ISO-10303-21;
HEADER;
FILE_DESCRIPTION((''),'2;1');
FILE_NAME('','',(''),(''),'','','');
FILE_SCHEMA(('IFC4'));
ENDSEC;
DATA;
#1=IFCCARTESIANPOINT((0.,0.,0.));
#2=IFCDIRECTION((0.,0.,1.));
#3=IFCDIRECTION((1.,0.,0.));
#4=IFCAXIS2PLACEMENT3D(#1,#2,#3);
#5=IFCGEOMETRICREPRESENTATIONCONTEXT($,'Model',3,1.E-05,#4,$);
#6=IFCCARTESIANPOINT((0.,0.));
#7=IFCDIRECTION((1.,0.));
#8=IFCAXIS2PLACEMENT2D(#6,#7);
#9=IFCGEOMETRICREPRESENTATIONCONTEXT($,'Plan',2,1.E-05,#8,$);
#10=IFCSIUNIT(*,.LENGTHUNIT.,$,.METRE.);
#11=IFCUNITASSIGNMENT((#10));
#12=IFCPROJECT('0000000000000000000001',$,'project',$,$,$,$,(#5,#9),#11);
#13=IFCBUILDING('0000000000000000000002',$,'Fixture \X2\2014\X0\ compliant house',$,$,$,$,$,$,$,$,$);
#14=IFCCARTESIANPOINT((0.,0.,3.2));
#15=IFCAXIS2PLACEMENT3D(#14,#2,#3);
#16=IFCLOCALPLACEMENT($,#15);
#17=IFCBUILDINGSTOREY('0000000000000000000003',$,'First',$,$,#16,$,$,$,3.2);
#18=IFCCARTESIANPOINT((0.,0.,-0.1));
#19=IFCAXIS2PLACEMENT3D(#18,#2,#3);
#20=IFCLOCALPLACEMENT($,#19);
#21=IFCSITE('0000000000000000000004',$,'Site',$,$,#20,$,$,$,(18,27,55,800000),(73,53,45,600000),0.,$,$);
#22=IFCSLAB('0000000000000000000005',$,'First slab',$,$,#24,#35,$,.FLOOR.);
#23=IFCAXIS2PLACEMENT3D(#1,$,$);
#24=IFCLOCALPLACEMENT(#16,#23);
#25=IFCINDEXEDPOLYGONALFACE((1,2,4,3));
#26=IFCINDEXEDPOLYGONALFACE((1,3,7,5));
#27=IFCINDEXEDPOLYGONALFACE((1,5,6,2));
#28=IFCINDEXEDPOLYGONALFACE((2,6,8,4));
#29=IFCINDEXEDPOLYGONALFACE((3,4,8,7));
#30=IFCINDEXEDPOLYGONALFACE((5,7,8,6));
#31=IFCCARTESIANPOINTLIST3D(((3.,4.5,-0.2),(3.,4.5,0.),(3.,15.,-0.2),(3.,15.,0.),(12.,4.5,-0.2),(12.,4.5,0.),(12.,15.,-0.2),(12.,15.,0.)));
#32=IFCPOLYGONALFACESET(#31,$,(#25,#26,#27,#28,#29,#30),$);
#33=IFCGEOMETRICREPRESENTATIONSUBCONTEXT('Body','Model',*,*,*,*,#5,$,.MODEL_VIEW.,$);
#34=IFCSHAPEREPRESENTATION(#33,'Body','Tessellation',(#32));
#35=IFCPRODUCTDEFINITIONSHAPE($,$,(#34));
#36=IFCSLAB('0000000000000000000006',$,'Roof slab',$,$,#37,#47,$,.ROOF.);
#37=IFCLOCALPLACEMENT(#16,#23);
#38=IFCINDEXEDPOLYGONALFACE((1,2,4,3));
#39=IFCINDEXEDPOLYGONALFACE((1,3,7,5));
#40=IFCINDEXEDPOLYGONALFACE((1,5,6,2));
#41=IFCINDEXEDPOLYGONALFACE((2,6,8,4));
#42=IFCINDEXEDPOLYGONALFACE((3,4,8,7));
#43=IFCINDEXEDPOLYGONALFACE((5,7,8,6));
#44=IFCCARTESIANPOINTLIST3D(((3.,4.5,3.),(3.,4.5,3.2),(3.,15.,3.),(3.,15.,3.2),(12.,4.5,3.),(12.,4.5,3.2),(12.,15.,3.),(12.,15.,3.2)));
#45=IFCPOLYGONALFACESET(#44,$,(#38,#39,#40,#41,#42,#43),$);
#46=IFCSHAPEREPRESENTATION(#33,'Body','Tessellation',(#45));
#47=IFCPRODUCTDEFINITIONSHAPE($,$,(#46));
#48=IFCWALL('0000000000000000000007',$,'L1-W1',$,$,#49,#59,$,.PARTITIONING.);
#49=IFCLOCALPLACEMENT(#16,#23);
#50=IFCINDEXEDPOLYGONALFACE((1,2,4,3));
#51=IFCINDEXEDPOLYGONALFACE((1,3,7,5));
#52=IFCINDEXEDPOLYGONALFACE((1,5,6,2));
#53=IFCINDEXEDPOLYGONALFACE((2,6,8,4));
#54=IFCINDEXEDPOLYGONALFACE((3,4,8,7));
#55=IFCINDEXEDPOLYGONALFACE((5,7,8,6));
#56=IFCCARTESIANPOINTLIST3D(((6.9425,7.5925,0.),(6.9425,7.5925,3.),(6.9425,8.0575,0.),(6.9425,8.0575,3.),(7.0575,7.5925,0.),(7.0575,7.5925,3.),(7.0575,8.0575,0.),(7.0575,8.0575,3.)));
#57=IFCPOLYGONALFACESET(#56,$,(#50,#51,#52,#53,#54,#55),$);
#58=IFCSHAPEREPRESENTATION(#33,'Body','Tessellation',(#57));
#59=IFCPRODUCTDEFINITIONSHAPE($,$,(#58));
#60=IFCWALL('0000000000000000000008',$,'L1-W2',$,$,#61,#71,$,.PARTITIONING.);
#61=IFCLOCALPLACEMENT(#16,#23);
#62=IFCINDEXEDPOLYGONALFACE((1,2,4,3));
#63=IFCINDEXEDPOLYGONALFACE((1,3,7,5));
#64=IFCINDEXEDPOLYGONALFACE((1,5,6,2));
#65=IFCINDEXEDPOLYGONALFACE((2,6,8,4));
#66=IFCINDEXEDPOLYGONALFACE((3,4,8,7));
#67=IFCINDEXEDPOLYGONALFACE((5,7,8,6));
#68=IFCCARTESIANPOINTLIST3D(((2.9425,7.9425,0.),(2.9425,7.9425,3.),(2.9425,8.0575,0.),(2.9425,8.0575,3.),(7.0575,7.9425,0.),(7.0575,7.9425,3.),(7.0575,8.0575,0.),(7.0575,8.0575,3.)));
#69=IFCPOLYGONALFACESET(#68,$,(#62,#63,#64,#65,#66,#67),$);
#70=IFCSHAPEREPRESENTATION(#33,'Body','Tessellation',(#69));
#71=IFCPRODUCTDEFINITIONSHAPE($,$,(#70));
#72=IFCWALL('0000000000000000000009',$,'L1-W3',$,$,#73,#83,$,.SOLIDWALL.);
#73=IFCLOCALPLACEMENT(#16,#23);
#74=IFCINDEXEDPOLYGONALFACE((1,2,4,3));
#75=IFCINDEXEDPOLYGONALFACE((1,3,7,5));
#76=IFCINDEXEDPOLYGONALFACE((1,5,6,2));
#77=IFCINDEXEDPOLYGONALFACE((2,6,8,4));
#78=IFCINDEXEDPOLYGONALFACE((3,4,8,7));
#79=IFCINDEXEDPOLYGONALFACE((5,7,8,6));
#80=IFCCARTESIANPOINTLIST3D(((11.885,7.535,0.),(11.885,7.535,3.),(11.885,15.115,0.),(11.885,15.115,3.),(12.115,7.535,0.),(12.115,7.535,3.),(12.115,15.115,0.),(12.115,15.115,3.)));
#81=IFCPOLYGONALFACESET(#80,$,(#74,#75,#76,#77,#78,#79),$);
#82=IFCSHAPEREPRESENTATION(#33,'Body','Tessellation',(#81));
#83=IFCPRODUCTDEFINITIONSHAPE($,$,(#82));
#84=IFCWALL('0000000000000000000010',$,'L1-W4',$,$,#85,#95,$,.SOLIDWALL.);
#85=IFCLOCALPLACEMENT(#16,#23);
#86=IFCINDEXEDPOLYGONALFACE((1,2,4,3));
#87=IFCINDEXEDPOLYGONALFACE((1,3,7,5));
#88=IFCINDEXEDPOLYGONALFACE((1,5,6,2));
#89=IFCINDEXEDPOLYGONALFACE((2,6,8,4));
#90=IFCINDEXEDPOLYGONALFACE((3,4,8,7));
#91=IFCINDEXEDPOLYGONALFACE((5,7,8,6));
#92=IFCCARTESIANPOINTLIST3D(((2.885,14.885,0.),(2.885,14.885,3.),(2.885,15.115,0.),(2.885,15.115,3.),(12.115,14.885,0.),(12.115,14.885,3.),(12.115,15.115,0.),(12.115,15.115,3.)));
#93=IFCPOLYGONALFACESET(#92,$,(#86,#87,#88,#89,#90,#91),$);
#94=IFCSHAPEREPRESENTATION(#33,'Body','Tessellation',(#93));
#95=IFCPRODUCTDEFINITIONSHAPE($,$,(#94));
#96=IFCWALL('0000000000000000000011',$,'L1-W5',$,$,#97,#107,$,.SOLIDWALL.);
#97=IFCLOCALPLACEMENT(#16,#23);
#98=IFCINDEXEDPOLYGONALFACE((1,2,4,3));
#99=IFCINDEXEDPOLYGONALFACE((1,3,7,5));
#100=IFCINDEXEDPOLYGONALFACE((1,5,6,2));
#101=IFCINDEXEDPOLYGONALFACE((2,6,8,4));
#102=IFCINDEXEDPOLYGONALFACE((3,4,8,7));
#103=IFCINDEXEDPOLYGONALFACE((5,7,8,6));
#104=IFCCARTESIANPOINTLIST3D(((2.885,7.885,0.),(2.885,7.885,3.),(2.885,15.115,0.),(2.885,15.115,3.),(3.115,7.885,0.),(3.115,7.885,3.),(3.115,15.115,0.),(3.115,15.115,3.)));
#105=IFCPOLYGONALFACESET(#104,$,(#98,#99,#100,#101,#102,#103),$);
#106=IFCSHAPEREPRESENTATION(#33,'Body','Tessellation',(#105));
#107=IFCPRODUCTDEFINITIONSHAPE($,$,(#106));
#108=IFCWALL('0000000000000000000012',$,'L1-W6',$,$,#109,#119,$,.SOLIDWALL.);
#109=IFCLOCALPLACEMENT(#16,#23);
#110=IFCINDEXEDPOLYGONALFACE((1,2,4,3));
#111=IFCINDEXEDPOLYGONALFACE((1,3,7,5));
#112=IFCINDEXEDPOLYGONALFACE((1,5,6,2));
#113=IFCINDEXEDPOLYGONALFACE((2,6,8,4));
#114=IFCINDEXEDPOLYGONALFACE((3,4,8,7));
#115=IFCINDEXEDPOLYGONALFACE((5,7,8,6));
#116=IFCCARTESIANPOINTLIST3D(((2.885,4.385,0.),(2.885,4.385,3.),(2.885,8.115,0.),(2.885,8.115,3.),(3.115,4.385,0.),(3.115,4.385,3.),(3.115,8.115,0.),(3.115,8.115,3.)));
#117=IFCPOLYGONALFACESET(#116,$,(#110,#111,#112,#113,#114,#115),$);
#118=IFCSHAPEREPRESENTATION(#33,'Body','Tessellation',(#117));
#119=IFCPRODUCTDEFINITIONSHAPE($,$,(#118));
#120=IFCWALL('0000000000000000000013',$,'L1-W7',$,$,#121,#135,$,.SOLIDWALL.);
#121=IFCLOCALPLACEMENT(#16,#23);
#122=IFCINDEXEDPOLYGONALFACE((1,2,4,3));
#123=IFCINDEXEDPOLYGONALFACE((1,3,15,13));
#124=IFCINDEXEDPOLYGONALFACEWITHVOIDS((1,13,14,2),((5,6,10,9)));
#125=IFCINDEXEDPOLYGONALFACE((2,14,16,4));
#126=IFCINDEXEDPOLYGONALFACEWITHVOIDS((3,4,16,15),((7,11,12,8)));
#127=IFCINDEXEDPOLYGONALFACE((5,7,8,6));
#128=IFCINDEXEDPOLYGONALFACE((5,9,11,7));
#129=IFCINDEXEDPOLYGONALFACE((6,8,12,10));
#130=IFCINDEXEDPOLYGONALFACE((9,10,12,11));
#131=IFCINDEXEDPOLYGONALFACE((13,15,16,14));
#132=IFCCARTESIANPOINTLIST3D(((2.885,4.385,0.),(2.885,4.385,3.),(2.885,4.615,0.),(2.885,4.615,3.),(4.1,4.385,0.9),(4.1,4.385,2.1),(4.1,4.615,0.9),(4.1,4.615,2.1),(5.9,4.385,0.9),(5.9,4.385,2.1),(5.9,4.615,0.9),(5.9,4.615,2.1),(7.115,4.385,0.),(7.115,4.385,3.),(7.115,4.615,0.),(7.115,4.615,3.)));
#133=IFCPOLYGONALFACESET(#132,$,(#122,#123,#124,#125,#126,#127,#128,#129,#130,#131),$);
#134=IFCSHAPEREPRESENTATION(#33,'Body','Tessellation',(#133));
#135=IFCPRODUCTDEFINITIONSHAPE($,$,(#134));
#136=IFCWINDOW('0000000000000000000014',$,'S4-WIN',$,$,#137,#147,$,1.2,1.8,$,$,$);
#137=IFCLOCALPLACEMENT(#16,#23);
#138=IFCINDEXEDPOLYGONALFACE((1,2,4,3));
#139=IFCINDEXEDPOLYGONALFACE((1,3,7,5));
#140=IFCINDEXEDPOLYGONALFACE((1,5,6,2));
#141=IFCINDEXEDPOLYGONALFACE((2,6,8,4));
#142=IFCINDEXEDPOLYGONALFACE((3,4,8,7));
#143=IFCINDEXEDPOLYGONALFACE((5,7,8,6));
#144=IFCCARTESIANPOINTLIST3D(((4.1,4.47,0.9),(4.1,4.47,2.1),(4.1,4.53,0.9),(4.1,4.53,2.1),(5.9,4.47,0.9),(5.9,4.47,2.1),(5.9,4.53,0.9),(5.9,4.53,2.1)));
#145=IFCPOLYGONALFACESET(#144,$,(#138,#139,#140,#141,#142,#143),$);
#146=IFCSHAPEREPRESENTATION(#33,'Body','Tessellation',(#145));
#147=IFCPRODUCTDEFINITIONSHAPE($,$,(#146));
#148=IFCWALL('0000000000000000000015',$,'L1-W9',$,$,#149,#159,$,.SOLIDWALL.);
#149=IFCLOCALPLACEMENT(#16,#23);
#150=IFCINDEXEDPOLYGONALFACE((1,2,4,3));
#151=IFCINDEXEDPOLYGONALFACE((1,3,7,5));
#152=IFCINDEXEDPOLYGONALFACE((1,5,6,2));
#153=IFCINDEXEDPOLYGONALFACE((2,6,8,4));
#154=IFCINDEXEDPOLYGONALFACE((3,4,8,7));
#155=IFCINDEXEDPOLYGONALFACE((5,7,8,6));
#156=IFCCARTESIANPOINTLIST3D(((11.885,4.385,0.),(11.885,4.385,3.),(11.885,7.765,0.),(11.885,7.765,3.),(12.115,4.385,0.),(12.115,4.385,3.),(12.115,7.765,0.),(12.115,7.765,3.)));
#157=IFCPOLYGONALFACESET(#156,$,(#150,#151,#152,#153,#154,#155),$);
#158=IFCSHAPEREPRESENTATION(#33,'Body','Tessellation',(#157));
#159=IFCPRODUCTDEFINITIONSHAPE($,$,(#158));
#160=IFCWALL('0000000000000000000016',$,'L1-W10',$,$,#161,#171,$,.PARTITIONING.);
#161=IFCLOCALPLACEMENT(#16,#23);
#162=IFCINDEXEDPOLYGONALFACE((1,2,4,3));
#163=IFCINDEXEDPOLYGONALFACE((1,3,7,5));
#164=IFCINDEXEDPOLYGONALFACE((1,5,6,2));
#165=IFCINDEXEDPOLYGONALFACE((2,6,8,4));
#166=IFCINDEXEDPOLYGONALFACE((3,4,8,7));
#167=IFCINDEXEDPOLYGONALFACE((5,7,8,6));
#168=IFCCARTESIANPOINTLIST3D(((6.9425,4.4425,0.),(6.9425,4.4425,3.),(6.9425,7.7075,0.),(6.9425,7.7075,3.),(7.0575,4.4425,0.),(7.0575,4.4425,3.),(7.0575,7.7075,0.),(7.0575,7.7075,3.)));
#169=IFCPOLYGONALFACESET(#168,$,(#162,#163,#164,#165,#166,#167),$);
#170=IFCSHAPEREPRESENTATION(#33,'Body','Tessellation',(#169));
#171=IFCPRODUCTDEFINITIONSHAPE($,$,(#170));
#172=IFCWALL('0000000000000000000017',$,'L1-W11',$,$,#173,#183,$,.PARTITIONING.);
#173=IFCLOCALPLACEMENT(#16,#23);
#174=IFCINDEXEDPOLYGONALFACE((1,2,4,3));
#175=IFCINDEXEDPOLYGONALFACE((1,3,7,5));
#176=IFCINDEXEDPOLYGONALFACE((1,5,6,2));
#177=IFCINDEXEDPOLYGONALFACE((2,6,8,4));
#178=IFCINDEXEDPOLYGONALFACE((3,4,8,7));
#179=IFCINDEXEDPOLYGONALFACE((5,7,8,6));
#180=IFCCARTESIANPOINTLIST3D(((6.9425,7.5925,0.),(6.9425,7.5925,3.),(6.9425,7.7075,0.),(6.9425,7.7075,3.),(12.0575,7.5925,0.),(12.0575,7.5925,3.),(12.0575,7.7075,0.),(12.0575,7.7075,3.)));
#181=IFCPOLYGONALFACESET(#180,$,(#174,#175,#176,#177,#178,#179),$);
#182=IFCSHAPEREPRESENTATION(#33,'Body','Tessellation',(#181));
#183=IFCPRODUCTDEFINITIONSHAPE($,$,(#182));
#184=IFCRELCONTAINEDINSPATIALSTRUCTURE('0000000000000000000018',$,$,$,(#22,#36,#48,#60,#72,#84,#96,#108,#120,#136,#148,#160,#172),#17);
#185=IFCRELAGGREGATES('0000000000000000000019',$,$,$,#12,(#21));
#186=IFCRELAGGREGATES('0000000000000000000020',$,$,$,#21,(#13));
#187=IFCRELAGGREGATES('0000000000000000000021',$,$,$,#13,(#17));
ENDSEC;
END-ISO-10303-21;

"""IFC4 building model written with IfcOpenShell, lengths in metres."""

from ifc_helpers import new_model, si_unit, frame, origin_with_axes, origin_2d_with_axis, place, context, subcontext, project, spatial, line, indexed_curve, outline, extrude, element, fill, save


model = new_model("IFC4")

# Units and contexts
model_context = context("Model", 3, precision=1e-05, world=origin_with_axes())
plan_context = context("Plan", 2, precision=1e-05, world=origin_2d_with_axis())
body_context = subcontext(model_context, "Body", "Model", "MODEL_VIEW")
ifc_project = project(units=[si_unit("LENGTHUNIT", "METRE")], contexts=[model_context, plan_context])

# Site, building, storey
site_placement = place(None, frame((0.0, 0.0, -0.1), z_axis=(0.0, 0.0, 1.0), x_axis=(1.0, 0.0, 0.0)))
site = spatial("IfcSite", under=ifc_project, at=site_placement, Name="Site", RefLatitude=(18, 27, 55, 800000), RefLongitude=(73, 53, 45, 600000), RefElevation=0.0)
building = spatial("IfcBuilding", under=site, Name="Fixture — compliant house")
storey_placement = place(None, frame((0.0, 0.0, 3.2), z_axis=(0.0, 0.0, 1.0), x_axis=(1.0, 0.0, 0.0)))
storey = spatial("IfcBuildingStorey", under=building, at=storey_placement, Name="First", Elevation=3.2)

# Slabs
slab_1_placement = place(storey_placement, frame((0.0, 0.0, -0.2), z_axis=(0.0, 0.0, 1.0), x_axis=(1.0, 0.0, 0.0)))
element("IfcSlab", 1, at=slab_1_placement, inside=storey, Name="First slab", PredefinedType="FLOOR", context=body_context, shape_type="SweptSolid", body=[
    extrude(outline(indexed_curve([(3.0, 4.5), (12.0, 4.5), (12.0, 15.0), (3.0, 15.0)], segments=[line(1, 2, 3, 4, 1)])), origin_with_axes(), (0.0, 0.0, 1.0), 0.2),
])
slab_2_placement = place(storey_placement, frame((0.0, 0.0, 3.0), z_axis=(0.0, 0.0, 1.0), x_axis=(1.0, 0.0, 0.0)))
element("IfcSlab", 2, at=slab_2_placement, inside=storey, Name="Roof slab", PredefinedType="ROOF", context=body_context, shape_type="SweptSolid", body=[
    extrude(outline(indexed_curve([(3.0, 4.5), (12.0, 4.5), (12.0, 15.0), (3.0, 15.0)], segments=[line(1, 2, 3, 4, 1)])), origin_with_axes(), (0.0, 0.0, 1.0), 0.2),
])

# Walls
wall_1_placement = place(storey_placement, frame((0.0, 0.0, -3.2), z_axis=(0.0, 0.0, 1.0), x_axis=(1.0, 0.0, 0.0)))
element("IfcWall", 3, at=wall_1_placement, inside=storey, Name="L1-W1", PredefinedType="PARTITIONING", context=body_context, shape_type="SweptSolid", body=[
    extrude(outline(indexed_curve([(6.9425, 7.5925), (6.9425, 8.0575), (7.0575, 8.0575), (7.0575, 7.5925)], segments=[line(1, 2, 3, 4, 1)])), frame((0.0, 0.0, 3.2), z_axis=(0.0, 0.0, 1.0), x_axis=(1.0, 0.0, 0.0)), (0.0, 0.0, 1.0), 3.0),
])
wall_2_placement = place(storey_placement, frame((0.0, 0.0, -3.2), z_axis=(0.0, 0.0, 1.0), x_axis=(1.0, 0.0, 0.0)))
element("IfcWall", 4, at=wall_2_placement, inside=storey, Name="L1-W2", PredefinedType="PARTITIONING", context=body_context, shape_type="SweptSolid", body=[
    extrude(outline(indexed_curve([(7.0575, 7.9425), (2.9425, 7.9425), (2.9425, 8.0575), (7.0575, 8.0575)], segments=[line(1, 2, 3, 4, 1)])), frame((0.0, 0.0, 3.2), z_axis=(0.0, 0.0, 1.0), x_axis=(1.0, 0.0, 0.0)), (0.0, 0.0, 1.0), 3.0),
])
wall_3_placement = place(storey_placement, frame((0.0, 0.0, -3.2), z_axis=(0.0, 0.0, 1.0), x_axis=(1.0, 0.0, 0.0)))
element("IfcWall", 5, at=wall_3_placement, inside=storey, Name="L1-W3", PredefinedType="SOLIDWALL", context=body_context, shape_type="SweptSolid", body=[
    extrude(outline(indexed_curve([(11.885, 7.535), (11.885, 15.115), (12.115, 15.115), (12.115, 7.535)], segments=[line(1, 2, 3, 4, 1)])), frame((0.0, 0.0, 3.2), z_axis=(0.0, 0.0, 1.0), x_axis=(1.0, 0.0, 0.0)), (0.0, 0.0, 1.0), 3.0),
])
wall_4_placement = place(storey_placement, frame((0.0, 0.0, -3.2), z_axis=(0.0, 0.0, 1.0), x_axis=(1.0, 0.0, 0.0)))
element("IfcWall", 6, at=wall_4_placement, inside=storey, Name="L1-W4", PredefinedType="SOLIDWALL", context=body_context, shape_type="SweptSolid", body=[
    extrude(outline(indexed_curve([(12.115, 14.885), (2.885, 14.885), (2.885, 15.115), (12.115, 15.115)], segments=[line(1, 2, 3, 4, 1)])), frame((0.0, 0.0, 3.2), z_axis=(0.0, 0.0, 1.0), x_axis=(1.0, 0.0, 0.0)), (0.0, 0.0, 1.0), 3.0),
])
wall_5_placement = place(storey_placement, frame((0.0, 0.0, -3.2), z_axis=(0.0, 0.0, 1.0), x_axis=(1.0, 0.0, 0.0)))
element("IfcWall", 7, at=wall_5_placement, inside=storey, Name="L1-W5", PredefinedType="SOLIDWALL", context=body_context, shape_type="SweptSolid", body=[
    extrude(outline(indexed_curve([(3.115, 15.115), (3.115, 7.885), (2.885, 7.885), (2.885, 15.115)], segments=[line(1, 2, 3, 4, 1)])), frame((0.0, 0.0, 3.2), z_axis=(0.0, 0.0, 1.0), x_axis=(1.0, 0.0, 0.0)), (0.0, 0.0, 1.0), 3.0),
])
wall_6_placement = place(storey_placement, frame((0.0, 0.0, -3.2), z_axis=(0.0, 0.0, 1.0), x_axis=(1.0, 0.0, 0.0)))
element("IfcWall", 8, at=wall_6_placement, inside=storey, Name="L1-W6", PredefinedType="SOLIDWALL", context=body_context, shape_type="SweptSolid", body=[
    extrude(outline(indexed_curve([(3.115, 8.115), (3.115, 4.385), (2.885, 4.385), (2.885, 8.115)], segments=[line(1, 2, 3, 4, 1)])), frame((0.0, 0.0, 3.2), z_axis=(0.0, 0.0, 1.0), x_axis=(1.0, 0.0, 0.0)), (0.0, 0.0, 1.0), 3.0),
])

# Wall, opening, window
wall_7_placement = place(storey_placement, frame((0.0, 0.0, -3.2), z_axis=(0.0, 0.0, 1.0), x_axis=(1.0, 0.0, 0.0)))
wall_7 = element("IfcWall", 9, at=wall_7_placement, inside=storey, Name="L1-W7", PredefinedType="SOLIDWALL", context=body_context, shape_type="SweptSolid", body=[
    extrude(outline(indexed_curve([(2.885, 4.615), (7.115, 4.615), (7.115, 4.385), (2.885, 4.385)], segments=[line(1, 2, 3, 4, 1)])), frame((0.0, 0.0, 3.2), z_axis=(0.0, 0.0, 1.0), x_axis=(1.0, 0.0, 0.0)), (0.0, 0.0, 1.0), 3.0),
])
opening_1_placement = place(wall_7_placement, origin_with_axes())
opening_1 = element("IfcOpeningElement", 10, at=opening_1_placement, cuts=wall_7, context=body_context, shape_type="SweptSolid", body=[
    extrude(outline(indexed_curve([(4.1, 4.665), (5.9, 4.665), (5.9, 4.335), (4.1, 4.335)], segments=[line(1, 2, 3, 4, 1)])), frame((0.0, 0.0, 4.1), z_axis=(0.0, 0.0, 1.0), x_axis=(1.0, 0.0, 0.0)), (0.0, 0.0, 1.0), 1.2),
])
window_1_placement = place(storey_placement, frame((0.0, 0.0, -3.2), z_axis=(0.0, 0.0, 1.0), x_axis=(1.0, 0.0, 0.0)))
window_1 = element("IfcWindow", 11, at=window_1_placement, inside=storey, Name="S4-WIN", OverallHeight=1.2, OverallWidth=1.8, context=body_context, shape_type="SweptSolid", body=[
    extrude(outline(indexed_curve([(4.1, 4.53), (5.9, 4.53), (5.9, 4.47), (4.1, 4.47)], segments=[line(1, 2, 3, 4, 1)])), frame((0.0, 0.0, 4.1), z_axis=(0.0, 0.0, 1.0), x_axis=(1.0, 0.0, 0.0)), (0.0, 0.0, 1.0), 1.2),
])
fill(opening_1, window_1)

# Walls
wall_8_placement = place(storey_placement, frame((0.0, 0.0, -3.2), z_axis=(0.0, 0.0, 1.0), x_axis=(1.0, 0.0, 0.0)))
element("IfcWall", 12, at=wall_8_placement, inside=storey, Name="L1-W9", PredefinedType="SOLIDWALL", context=body_context, shape_type="SweptSolid", body=[
    extrude(outline(indexed_curve([(11.885, 4.385), (11.885, 7.765), (12.115, 7.765), (12.115, 4.385)], segments=[line(1, 2, 3, 4, 1)])), frame((0.0, 0.0, 3.2), z_axis=(0.0, 0.0, 1.0), x_axis=(1.0, 0.0, 0.0)), (0.0, 0.0, 1.0), 3.0),
])
wall_9_placement = place(storey_placement, frame((0.0, 0.0, -3.2), z_axis=(0.0, 0.0, 1.0), x_axis=(1.0, 0.0, 0.0)))
element("IfcWall", 13, at=wall_9_placement, inside=storey, Name="L1-W10", PredefinedType="PARTITIONING", context=body_context, shape_type="SweptSolid", body=[
    extrude(outline(indexed_curve([(6.9425, 4.4425), (6.9425, 7.7075), (7.0575, 7.7075), (7.0575, 4.4425)], segments=[line(1, 2, 3, 4, 1)])), frame((0.0, 0.0, 3.2), z_axis=(0.0, 0.0, 1.0), x_axis=(1.0, 0.0, 0.0)), (0.0, 0.0, 1.0), 3.0),
])
wall_10_placement = place(storey_placement, frame((0.0, 0.0, -3.2), z_axis=(0.0, 0.0, 1.0), x_axis=(1.0, 0.0, 0.0)))
element("IfcWall", 14, at=wall_10_placement, inside=storey, Name="L1-W11", PredefinedType="PARTITIONING", context=body_context, shape_type="SweptSolid", body=[
    extrude(outline(indexed_curve([(12.0575, 7.5925), (6.9425, 7.5925), (6.9425, 7.7075), (12.0575, 7.7075)], segments=[line(1, 2, 3, 4, 1)])), frame((0.0, 0.0, 3.2), z_axis=(0.0, 0.0, 1.0), x_axis=(1.0, 0.0, 0.0)), (0.0, 0.0, 1.0), 3.0),
])

save(model, "model.ifc")
